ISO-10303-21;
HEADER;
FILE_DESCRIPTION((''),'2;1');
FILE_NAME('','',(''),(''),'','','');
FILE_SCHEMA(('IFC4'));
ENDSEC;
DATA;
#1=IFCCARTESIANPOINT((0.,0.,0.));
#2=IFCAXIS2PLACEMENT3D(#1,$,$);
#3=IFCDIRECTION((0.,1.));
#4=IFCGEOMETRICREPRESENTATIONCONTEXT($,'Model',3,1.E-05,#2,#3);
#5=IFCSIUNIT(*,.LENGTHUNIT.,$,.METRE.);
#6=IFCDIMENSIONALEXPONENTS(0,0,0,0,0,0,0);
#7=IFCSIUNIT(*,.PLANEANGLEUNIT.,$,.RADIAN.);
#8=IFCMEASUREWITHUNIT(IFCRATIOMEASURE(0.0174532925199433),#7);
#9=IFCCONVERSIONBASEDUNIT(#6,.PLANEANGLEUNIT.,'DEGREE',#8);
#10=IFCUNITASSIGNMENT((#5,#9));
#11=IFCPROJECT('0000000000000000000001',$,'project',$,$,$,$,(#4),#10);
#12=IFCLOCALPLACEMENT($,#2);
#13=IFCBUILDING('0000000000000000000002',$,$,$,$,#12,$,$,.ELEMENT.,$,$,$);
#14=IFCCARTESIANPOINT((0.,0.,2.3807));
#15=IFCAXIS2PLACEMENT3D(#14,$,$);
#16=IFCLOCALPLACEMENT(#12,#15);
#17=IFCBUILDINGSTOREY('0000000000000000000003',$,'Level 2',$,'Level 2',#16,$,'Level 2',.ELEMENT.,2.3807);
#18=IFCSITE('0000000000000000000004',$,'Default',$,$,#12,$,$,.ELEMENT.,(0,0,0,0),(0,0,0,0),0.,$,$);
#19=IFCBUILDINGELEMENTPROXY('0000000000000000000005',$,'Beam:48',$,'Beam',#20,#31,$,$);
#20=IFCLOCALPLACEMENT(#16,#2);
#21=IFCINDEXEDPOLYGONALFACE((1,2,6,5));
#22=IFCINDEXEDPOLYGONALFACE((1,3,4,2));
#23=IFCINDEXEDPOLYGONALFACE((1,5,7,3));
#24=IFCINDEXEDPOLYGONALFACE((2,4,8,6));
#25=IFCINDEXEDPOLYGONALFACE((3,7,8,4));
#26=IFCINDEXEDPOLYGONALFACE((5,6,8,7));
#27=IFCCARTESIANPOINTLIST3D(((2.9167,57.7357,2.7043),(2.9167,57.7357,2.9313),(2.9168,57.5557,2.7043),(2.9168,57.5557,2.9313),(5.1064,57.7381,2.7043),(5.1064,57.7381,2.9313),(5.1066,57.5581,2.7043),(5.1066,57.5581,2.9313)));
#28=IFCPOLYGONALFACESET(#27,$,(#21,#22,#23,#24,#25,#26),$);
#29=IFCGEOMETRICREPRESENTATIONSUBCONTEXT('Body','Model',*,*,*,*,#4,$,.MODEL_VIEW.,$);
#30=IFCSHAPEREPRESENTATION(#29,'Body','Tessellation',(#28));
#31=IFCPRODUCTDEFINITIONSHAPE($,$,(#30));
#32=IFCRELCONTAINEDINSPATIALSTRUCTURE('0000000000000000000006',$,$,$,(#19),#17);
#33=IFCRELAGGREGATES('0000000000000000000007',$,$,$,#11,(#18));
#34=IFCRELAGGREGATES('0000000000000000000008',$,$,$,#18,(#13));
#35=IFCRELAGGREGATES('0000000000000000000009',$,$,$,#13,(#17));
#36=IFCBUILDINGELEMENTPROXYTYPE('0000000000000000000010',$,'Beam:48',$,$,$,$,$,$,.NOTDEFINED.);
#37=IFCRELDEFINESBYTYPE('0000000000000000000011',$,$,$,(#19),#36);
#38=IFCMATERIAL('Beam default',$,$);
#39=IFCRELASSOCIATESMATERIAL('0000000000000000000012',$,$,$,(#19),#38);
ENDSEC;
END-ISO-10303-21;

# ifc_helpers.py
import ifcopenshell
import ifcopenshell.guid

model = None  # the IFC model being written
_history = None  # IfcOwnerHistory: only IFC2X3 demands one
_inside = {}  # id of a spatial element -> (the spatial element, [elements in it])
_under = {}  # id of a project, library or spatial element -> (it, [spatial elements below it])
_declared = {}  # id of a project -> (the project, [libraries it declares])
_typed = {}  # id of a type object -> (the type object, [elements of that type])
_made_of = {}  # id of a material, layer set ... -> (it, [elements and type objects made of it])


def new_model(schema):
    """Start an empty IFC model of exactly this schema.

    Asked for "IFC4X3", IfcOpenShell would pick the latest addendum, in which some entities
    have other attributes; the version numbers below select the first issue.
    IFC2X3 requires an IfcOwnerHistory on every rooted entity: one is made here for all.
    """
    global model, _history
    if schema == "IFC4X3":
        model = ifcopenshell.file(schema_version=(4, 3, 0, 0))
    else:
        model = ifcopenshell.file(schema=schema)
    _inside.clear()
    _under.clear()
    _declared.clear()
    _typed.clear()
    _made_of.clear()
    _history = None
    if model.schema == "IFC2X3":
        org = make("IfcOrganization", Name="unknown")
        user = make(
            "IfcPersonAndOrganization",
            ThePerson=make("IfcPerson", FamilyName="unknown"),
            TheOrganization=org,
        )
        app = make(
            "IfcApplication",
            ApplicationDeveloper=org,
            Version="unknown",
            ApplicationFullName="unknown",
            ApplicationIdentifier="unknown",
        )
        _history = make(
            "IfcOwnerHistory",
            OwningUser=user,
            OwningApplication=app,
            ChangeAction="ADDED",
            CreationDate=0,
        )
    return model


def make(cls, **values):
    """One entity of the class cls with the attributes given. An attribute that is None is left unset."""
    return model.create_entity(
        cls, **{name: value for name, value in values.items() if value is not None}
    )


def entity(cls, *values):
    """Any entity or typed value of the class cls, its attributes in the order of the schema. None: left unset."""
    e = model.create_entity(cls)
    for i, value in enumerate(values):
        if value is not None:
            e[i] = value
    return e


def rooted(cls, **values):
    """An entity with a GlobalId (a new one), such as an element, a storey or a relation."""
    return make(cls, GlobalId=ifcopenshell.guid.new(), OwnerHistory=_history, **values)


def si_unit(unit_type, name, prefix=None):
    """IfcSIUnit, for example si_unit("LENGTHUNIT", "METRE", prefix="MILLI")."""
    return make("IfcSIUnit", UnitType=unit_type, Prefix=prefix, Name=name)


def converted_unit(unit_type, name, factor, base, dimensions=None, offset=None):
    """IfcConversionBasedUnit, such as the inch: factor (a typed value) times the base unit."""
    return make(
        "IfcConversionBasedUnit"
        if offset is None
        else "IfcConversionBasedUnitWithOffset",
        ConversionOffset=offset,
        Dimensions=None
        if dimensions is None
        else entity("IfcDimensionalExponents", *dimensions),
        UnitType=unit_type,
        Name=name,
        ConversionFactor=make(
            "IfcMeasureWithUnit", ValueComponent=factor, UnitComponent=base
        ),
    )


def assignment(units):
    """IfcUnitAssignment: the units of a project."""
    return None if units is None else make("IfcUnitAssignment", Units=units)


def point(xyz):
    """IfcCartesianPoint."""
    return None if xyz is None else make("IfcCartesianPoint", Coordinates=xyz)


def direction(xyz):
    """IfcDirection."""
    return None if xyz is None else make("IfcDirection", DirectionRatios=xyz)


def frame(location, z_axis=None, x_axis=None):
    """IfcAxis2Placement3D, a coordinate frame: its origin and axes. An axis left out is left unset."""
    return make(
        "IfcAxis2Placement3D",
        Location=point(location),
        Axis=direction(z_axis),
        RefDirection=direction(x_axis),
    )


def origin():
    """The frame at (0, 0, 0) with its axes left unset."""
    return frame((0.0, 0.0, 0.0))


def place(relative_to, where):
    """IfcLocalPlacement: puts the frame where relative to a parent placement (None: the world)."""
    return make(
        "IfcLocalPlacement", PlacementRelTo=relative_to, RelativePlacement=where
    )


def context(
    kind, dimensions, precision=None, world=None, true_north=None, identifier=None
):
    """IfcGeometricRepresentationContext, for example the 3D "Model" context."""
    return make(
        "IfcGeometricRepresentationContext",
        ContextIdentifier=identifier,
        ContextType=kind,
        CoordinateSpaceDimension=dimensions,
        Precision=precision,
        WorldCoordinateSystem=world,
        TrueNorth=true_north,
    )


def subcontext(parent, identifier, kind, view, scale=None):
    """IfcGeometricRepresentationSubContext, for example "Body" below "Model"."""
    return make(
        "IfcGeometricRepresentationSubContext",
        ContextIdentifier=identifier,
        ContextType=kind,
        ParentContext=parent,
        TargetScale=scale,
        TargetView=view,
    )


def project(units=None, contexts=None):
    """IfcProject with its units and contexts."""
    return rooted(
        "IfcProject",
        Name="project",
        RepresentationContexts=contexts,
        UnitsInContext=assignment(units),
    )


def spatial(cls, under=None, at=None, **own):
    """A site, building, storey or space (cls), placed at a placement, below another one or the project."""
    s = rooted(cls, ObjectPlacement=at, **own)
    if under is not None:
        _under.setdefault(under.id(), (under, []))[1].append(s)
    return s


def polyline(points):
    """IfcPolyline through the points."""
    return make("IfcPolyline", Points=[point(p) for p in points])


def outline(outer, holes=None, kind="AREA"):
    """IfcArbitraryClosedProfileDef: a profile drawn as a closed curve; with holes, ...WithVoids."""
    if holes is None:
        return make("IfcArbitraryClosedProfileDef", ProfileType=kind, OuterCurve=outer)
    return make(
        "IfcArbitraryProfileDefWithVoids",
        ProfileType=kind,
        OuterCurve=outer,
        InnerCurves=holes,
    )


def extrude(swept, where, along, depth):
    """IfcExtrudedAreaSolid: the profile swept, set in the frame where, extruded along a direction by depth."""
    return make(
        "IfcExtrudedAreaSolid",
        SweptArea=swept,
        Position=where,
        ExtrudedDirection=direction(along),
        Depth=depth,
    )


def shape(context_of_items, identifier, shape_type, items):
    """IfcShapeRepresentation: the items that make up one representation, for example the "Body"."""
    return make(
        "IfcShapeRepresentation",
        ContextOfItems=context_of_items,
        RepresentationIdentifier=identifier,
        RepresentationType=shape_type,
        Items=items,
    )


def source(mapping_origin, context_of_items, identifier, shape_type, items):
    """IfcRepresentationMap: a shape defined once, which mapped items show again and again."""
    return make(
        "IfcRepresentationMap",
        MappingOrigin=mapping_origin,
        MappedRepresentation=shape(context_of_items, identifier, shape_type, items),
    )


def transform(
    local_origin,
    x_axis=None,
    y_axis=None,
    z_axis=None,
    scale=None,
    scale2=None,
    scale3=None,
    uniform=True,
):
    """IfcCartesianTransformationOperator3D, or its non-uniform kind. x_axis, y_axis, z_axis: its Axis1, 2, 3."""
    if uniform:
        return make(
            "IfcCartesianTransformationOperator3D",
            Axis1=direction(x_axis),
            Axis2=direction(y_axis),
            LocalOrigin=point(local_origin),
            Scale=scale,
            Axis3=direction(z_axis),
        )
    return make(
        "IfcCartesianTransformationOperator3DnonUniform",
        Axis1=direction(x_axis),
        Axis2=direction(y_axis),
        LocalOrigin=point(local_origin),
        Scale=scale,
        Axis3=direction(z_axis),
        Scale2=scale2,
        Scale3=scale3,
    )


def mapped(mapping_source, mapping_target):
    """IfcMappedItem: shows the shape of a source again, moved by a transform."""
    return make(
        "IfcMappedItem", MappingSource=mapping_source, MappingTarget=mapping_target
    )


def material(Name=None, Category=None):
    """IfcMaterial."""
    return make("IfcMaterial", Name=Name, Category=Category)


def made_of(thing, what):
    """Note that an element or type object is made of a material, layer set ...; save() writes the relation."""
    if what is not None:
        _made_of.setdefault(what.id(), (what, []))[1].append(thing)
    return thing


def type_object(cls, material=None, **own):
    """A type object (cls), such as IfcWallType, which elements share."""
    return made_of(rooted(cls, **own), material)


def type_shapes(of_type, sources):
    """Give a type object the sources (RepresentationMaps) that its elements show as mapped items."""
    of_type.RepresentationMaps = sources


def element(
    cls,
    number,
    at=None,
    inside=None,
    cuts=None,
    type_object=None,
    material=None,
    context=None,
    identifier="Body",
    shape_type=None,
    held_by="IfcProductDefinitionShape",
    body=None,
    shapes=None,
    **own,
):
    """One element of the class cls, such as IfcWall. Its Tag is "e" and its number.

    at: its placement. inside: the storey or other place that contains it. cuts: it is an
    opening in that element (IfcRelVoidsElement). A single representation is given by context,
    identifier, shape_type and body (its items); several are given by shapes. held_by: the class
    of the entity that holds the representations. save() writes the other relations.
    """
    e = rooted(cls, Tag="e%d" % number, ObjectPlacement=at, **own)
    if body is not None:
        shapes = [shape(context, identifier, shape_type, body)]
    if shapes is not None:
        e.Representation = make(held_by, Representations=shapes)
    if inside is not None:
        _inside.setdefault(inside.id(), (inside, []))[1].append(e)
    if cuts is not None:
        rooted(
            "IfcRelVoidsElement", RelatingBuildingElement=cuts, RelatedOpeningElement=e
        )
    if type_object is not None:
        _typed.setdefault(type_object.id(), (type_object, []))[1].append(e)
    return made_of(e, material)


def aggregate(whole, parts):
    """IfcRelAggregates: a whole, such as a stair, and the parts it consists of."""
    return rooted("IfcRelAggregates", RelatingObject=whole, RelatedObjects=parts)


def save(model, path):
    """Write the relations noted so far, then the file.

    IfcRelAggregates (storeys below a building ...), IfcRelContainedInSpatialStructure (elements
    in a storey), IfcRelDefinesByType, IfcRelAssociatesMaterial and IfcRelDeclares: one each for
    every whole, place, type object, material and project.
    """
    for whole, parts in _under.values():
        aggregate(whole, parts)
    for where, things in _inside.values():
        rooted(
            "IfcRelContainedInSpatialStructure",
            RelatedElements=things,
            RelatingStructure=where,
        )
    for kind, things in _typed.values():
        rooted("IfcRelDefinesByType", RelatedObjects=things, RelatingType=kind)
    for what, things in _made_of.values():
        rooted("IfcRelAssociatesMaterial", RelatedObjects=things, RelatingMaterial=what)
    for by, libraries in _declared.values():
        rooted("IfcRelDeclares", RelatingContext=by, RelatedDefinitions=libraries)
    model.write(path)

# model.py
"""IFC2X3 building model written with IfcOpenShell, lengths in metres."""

from ifc_helpers import new_model, entity, si_unit, converted_unit, direction, frame, origin, place, context, subcontext, project, spatial, polyline, outline, extrude, source, transform, mapped, material, type_object, type_shapes, element, save


model = new_model("IFC2X3")

# Units and contexts
model_context = context("Model", 3, precision=1e-05, world=origin(), true_north=direction((0.0, 1.0)))
body_context = subcontext(model_context, "Body", "Model", "MODEL_VIEW")
ifc_project = project(units=[si_unit("LENGTHUNIT", "METRE"), converted_unit("PLANEANGLEUNIT", "DEGREE", entity("IfcRatioMeasure", 0.0174532925199433), si_unit("PLANEANGLEUNIT", "RADIAN"), dimensions=[0, 0, 0, 0, 0, 0, 0])], contexts=[model_context])

# Site, building, storey
placement_1 = place(None, origin())
site = spatial("IfcSite", under=ifc_project, at=placement_1, Name="Default", CompositionType="ELEMENT", RefLatitude=(0, 0, 0, 0), RefLongitude=(0, 0, 0, 0), RefElevation=0.0)
building = spatial("IfcBuilding", under=site, at=placement_1, CompositionType="ELEMENT")
storey_placement = place(placement_1, frame((0.0, 0.0, 2.3807)))
storey = spatial("IfcBuildingStorey", under=building, at=storey_placement, Name="Level 2", ObjectType="Level 2", LongName="Level 2", CompositionType="ELEMENT", Elevation=2.3807)

# Building element proxy
ifc_material_1 = material(Name="Beam default")
building_element_proxy_type = type_object("IfcBuildingElementProxyType", Name="Beam:48", PredefinedType="NOTDEFINED")
shared_shape_1 = source(origin(), body_context, "Body", "SweptSolid", [
    extrude(outline(polyline([(2.1897, -0.09), (2.1897, 0.09), (0.0, 0.09), (0.0, -0.09), (2.1897, -0.09)])), origin(), (0.0, 0.0, 1.0), 0.227),
])
type_shapes(building_element_proxy_type, [shared_shape_1])
placement_2 = place(placement_1, frame((0.0, 0.0, 5.085)))
proxy_placement = place(placement_2, frame((2.9168, 57.6457, 0.0), z_axis=(0.0, 0.0, 1.0), x_axis=(0.999999, 0.001085, 0.0)))
element("IfcBuildingElementProxy", 1, at=proxy_placement, inside=storey, type_object=building_element_proxy_type, material=ifc_material_1, Name="Beam:48", ObjectType="Beam", context=body_context, shape_type="MappedRepresentation", body=[
    mapped(shared_shape_1, transform((0.0, 0.0, 0.0), scale=1.0)),
])

save(model, "model.ifc")
